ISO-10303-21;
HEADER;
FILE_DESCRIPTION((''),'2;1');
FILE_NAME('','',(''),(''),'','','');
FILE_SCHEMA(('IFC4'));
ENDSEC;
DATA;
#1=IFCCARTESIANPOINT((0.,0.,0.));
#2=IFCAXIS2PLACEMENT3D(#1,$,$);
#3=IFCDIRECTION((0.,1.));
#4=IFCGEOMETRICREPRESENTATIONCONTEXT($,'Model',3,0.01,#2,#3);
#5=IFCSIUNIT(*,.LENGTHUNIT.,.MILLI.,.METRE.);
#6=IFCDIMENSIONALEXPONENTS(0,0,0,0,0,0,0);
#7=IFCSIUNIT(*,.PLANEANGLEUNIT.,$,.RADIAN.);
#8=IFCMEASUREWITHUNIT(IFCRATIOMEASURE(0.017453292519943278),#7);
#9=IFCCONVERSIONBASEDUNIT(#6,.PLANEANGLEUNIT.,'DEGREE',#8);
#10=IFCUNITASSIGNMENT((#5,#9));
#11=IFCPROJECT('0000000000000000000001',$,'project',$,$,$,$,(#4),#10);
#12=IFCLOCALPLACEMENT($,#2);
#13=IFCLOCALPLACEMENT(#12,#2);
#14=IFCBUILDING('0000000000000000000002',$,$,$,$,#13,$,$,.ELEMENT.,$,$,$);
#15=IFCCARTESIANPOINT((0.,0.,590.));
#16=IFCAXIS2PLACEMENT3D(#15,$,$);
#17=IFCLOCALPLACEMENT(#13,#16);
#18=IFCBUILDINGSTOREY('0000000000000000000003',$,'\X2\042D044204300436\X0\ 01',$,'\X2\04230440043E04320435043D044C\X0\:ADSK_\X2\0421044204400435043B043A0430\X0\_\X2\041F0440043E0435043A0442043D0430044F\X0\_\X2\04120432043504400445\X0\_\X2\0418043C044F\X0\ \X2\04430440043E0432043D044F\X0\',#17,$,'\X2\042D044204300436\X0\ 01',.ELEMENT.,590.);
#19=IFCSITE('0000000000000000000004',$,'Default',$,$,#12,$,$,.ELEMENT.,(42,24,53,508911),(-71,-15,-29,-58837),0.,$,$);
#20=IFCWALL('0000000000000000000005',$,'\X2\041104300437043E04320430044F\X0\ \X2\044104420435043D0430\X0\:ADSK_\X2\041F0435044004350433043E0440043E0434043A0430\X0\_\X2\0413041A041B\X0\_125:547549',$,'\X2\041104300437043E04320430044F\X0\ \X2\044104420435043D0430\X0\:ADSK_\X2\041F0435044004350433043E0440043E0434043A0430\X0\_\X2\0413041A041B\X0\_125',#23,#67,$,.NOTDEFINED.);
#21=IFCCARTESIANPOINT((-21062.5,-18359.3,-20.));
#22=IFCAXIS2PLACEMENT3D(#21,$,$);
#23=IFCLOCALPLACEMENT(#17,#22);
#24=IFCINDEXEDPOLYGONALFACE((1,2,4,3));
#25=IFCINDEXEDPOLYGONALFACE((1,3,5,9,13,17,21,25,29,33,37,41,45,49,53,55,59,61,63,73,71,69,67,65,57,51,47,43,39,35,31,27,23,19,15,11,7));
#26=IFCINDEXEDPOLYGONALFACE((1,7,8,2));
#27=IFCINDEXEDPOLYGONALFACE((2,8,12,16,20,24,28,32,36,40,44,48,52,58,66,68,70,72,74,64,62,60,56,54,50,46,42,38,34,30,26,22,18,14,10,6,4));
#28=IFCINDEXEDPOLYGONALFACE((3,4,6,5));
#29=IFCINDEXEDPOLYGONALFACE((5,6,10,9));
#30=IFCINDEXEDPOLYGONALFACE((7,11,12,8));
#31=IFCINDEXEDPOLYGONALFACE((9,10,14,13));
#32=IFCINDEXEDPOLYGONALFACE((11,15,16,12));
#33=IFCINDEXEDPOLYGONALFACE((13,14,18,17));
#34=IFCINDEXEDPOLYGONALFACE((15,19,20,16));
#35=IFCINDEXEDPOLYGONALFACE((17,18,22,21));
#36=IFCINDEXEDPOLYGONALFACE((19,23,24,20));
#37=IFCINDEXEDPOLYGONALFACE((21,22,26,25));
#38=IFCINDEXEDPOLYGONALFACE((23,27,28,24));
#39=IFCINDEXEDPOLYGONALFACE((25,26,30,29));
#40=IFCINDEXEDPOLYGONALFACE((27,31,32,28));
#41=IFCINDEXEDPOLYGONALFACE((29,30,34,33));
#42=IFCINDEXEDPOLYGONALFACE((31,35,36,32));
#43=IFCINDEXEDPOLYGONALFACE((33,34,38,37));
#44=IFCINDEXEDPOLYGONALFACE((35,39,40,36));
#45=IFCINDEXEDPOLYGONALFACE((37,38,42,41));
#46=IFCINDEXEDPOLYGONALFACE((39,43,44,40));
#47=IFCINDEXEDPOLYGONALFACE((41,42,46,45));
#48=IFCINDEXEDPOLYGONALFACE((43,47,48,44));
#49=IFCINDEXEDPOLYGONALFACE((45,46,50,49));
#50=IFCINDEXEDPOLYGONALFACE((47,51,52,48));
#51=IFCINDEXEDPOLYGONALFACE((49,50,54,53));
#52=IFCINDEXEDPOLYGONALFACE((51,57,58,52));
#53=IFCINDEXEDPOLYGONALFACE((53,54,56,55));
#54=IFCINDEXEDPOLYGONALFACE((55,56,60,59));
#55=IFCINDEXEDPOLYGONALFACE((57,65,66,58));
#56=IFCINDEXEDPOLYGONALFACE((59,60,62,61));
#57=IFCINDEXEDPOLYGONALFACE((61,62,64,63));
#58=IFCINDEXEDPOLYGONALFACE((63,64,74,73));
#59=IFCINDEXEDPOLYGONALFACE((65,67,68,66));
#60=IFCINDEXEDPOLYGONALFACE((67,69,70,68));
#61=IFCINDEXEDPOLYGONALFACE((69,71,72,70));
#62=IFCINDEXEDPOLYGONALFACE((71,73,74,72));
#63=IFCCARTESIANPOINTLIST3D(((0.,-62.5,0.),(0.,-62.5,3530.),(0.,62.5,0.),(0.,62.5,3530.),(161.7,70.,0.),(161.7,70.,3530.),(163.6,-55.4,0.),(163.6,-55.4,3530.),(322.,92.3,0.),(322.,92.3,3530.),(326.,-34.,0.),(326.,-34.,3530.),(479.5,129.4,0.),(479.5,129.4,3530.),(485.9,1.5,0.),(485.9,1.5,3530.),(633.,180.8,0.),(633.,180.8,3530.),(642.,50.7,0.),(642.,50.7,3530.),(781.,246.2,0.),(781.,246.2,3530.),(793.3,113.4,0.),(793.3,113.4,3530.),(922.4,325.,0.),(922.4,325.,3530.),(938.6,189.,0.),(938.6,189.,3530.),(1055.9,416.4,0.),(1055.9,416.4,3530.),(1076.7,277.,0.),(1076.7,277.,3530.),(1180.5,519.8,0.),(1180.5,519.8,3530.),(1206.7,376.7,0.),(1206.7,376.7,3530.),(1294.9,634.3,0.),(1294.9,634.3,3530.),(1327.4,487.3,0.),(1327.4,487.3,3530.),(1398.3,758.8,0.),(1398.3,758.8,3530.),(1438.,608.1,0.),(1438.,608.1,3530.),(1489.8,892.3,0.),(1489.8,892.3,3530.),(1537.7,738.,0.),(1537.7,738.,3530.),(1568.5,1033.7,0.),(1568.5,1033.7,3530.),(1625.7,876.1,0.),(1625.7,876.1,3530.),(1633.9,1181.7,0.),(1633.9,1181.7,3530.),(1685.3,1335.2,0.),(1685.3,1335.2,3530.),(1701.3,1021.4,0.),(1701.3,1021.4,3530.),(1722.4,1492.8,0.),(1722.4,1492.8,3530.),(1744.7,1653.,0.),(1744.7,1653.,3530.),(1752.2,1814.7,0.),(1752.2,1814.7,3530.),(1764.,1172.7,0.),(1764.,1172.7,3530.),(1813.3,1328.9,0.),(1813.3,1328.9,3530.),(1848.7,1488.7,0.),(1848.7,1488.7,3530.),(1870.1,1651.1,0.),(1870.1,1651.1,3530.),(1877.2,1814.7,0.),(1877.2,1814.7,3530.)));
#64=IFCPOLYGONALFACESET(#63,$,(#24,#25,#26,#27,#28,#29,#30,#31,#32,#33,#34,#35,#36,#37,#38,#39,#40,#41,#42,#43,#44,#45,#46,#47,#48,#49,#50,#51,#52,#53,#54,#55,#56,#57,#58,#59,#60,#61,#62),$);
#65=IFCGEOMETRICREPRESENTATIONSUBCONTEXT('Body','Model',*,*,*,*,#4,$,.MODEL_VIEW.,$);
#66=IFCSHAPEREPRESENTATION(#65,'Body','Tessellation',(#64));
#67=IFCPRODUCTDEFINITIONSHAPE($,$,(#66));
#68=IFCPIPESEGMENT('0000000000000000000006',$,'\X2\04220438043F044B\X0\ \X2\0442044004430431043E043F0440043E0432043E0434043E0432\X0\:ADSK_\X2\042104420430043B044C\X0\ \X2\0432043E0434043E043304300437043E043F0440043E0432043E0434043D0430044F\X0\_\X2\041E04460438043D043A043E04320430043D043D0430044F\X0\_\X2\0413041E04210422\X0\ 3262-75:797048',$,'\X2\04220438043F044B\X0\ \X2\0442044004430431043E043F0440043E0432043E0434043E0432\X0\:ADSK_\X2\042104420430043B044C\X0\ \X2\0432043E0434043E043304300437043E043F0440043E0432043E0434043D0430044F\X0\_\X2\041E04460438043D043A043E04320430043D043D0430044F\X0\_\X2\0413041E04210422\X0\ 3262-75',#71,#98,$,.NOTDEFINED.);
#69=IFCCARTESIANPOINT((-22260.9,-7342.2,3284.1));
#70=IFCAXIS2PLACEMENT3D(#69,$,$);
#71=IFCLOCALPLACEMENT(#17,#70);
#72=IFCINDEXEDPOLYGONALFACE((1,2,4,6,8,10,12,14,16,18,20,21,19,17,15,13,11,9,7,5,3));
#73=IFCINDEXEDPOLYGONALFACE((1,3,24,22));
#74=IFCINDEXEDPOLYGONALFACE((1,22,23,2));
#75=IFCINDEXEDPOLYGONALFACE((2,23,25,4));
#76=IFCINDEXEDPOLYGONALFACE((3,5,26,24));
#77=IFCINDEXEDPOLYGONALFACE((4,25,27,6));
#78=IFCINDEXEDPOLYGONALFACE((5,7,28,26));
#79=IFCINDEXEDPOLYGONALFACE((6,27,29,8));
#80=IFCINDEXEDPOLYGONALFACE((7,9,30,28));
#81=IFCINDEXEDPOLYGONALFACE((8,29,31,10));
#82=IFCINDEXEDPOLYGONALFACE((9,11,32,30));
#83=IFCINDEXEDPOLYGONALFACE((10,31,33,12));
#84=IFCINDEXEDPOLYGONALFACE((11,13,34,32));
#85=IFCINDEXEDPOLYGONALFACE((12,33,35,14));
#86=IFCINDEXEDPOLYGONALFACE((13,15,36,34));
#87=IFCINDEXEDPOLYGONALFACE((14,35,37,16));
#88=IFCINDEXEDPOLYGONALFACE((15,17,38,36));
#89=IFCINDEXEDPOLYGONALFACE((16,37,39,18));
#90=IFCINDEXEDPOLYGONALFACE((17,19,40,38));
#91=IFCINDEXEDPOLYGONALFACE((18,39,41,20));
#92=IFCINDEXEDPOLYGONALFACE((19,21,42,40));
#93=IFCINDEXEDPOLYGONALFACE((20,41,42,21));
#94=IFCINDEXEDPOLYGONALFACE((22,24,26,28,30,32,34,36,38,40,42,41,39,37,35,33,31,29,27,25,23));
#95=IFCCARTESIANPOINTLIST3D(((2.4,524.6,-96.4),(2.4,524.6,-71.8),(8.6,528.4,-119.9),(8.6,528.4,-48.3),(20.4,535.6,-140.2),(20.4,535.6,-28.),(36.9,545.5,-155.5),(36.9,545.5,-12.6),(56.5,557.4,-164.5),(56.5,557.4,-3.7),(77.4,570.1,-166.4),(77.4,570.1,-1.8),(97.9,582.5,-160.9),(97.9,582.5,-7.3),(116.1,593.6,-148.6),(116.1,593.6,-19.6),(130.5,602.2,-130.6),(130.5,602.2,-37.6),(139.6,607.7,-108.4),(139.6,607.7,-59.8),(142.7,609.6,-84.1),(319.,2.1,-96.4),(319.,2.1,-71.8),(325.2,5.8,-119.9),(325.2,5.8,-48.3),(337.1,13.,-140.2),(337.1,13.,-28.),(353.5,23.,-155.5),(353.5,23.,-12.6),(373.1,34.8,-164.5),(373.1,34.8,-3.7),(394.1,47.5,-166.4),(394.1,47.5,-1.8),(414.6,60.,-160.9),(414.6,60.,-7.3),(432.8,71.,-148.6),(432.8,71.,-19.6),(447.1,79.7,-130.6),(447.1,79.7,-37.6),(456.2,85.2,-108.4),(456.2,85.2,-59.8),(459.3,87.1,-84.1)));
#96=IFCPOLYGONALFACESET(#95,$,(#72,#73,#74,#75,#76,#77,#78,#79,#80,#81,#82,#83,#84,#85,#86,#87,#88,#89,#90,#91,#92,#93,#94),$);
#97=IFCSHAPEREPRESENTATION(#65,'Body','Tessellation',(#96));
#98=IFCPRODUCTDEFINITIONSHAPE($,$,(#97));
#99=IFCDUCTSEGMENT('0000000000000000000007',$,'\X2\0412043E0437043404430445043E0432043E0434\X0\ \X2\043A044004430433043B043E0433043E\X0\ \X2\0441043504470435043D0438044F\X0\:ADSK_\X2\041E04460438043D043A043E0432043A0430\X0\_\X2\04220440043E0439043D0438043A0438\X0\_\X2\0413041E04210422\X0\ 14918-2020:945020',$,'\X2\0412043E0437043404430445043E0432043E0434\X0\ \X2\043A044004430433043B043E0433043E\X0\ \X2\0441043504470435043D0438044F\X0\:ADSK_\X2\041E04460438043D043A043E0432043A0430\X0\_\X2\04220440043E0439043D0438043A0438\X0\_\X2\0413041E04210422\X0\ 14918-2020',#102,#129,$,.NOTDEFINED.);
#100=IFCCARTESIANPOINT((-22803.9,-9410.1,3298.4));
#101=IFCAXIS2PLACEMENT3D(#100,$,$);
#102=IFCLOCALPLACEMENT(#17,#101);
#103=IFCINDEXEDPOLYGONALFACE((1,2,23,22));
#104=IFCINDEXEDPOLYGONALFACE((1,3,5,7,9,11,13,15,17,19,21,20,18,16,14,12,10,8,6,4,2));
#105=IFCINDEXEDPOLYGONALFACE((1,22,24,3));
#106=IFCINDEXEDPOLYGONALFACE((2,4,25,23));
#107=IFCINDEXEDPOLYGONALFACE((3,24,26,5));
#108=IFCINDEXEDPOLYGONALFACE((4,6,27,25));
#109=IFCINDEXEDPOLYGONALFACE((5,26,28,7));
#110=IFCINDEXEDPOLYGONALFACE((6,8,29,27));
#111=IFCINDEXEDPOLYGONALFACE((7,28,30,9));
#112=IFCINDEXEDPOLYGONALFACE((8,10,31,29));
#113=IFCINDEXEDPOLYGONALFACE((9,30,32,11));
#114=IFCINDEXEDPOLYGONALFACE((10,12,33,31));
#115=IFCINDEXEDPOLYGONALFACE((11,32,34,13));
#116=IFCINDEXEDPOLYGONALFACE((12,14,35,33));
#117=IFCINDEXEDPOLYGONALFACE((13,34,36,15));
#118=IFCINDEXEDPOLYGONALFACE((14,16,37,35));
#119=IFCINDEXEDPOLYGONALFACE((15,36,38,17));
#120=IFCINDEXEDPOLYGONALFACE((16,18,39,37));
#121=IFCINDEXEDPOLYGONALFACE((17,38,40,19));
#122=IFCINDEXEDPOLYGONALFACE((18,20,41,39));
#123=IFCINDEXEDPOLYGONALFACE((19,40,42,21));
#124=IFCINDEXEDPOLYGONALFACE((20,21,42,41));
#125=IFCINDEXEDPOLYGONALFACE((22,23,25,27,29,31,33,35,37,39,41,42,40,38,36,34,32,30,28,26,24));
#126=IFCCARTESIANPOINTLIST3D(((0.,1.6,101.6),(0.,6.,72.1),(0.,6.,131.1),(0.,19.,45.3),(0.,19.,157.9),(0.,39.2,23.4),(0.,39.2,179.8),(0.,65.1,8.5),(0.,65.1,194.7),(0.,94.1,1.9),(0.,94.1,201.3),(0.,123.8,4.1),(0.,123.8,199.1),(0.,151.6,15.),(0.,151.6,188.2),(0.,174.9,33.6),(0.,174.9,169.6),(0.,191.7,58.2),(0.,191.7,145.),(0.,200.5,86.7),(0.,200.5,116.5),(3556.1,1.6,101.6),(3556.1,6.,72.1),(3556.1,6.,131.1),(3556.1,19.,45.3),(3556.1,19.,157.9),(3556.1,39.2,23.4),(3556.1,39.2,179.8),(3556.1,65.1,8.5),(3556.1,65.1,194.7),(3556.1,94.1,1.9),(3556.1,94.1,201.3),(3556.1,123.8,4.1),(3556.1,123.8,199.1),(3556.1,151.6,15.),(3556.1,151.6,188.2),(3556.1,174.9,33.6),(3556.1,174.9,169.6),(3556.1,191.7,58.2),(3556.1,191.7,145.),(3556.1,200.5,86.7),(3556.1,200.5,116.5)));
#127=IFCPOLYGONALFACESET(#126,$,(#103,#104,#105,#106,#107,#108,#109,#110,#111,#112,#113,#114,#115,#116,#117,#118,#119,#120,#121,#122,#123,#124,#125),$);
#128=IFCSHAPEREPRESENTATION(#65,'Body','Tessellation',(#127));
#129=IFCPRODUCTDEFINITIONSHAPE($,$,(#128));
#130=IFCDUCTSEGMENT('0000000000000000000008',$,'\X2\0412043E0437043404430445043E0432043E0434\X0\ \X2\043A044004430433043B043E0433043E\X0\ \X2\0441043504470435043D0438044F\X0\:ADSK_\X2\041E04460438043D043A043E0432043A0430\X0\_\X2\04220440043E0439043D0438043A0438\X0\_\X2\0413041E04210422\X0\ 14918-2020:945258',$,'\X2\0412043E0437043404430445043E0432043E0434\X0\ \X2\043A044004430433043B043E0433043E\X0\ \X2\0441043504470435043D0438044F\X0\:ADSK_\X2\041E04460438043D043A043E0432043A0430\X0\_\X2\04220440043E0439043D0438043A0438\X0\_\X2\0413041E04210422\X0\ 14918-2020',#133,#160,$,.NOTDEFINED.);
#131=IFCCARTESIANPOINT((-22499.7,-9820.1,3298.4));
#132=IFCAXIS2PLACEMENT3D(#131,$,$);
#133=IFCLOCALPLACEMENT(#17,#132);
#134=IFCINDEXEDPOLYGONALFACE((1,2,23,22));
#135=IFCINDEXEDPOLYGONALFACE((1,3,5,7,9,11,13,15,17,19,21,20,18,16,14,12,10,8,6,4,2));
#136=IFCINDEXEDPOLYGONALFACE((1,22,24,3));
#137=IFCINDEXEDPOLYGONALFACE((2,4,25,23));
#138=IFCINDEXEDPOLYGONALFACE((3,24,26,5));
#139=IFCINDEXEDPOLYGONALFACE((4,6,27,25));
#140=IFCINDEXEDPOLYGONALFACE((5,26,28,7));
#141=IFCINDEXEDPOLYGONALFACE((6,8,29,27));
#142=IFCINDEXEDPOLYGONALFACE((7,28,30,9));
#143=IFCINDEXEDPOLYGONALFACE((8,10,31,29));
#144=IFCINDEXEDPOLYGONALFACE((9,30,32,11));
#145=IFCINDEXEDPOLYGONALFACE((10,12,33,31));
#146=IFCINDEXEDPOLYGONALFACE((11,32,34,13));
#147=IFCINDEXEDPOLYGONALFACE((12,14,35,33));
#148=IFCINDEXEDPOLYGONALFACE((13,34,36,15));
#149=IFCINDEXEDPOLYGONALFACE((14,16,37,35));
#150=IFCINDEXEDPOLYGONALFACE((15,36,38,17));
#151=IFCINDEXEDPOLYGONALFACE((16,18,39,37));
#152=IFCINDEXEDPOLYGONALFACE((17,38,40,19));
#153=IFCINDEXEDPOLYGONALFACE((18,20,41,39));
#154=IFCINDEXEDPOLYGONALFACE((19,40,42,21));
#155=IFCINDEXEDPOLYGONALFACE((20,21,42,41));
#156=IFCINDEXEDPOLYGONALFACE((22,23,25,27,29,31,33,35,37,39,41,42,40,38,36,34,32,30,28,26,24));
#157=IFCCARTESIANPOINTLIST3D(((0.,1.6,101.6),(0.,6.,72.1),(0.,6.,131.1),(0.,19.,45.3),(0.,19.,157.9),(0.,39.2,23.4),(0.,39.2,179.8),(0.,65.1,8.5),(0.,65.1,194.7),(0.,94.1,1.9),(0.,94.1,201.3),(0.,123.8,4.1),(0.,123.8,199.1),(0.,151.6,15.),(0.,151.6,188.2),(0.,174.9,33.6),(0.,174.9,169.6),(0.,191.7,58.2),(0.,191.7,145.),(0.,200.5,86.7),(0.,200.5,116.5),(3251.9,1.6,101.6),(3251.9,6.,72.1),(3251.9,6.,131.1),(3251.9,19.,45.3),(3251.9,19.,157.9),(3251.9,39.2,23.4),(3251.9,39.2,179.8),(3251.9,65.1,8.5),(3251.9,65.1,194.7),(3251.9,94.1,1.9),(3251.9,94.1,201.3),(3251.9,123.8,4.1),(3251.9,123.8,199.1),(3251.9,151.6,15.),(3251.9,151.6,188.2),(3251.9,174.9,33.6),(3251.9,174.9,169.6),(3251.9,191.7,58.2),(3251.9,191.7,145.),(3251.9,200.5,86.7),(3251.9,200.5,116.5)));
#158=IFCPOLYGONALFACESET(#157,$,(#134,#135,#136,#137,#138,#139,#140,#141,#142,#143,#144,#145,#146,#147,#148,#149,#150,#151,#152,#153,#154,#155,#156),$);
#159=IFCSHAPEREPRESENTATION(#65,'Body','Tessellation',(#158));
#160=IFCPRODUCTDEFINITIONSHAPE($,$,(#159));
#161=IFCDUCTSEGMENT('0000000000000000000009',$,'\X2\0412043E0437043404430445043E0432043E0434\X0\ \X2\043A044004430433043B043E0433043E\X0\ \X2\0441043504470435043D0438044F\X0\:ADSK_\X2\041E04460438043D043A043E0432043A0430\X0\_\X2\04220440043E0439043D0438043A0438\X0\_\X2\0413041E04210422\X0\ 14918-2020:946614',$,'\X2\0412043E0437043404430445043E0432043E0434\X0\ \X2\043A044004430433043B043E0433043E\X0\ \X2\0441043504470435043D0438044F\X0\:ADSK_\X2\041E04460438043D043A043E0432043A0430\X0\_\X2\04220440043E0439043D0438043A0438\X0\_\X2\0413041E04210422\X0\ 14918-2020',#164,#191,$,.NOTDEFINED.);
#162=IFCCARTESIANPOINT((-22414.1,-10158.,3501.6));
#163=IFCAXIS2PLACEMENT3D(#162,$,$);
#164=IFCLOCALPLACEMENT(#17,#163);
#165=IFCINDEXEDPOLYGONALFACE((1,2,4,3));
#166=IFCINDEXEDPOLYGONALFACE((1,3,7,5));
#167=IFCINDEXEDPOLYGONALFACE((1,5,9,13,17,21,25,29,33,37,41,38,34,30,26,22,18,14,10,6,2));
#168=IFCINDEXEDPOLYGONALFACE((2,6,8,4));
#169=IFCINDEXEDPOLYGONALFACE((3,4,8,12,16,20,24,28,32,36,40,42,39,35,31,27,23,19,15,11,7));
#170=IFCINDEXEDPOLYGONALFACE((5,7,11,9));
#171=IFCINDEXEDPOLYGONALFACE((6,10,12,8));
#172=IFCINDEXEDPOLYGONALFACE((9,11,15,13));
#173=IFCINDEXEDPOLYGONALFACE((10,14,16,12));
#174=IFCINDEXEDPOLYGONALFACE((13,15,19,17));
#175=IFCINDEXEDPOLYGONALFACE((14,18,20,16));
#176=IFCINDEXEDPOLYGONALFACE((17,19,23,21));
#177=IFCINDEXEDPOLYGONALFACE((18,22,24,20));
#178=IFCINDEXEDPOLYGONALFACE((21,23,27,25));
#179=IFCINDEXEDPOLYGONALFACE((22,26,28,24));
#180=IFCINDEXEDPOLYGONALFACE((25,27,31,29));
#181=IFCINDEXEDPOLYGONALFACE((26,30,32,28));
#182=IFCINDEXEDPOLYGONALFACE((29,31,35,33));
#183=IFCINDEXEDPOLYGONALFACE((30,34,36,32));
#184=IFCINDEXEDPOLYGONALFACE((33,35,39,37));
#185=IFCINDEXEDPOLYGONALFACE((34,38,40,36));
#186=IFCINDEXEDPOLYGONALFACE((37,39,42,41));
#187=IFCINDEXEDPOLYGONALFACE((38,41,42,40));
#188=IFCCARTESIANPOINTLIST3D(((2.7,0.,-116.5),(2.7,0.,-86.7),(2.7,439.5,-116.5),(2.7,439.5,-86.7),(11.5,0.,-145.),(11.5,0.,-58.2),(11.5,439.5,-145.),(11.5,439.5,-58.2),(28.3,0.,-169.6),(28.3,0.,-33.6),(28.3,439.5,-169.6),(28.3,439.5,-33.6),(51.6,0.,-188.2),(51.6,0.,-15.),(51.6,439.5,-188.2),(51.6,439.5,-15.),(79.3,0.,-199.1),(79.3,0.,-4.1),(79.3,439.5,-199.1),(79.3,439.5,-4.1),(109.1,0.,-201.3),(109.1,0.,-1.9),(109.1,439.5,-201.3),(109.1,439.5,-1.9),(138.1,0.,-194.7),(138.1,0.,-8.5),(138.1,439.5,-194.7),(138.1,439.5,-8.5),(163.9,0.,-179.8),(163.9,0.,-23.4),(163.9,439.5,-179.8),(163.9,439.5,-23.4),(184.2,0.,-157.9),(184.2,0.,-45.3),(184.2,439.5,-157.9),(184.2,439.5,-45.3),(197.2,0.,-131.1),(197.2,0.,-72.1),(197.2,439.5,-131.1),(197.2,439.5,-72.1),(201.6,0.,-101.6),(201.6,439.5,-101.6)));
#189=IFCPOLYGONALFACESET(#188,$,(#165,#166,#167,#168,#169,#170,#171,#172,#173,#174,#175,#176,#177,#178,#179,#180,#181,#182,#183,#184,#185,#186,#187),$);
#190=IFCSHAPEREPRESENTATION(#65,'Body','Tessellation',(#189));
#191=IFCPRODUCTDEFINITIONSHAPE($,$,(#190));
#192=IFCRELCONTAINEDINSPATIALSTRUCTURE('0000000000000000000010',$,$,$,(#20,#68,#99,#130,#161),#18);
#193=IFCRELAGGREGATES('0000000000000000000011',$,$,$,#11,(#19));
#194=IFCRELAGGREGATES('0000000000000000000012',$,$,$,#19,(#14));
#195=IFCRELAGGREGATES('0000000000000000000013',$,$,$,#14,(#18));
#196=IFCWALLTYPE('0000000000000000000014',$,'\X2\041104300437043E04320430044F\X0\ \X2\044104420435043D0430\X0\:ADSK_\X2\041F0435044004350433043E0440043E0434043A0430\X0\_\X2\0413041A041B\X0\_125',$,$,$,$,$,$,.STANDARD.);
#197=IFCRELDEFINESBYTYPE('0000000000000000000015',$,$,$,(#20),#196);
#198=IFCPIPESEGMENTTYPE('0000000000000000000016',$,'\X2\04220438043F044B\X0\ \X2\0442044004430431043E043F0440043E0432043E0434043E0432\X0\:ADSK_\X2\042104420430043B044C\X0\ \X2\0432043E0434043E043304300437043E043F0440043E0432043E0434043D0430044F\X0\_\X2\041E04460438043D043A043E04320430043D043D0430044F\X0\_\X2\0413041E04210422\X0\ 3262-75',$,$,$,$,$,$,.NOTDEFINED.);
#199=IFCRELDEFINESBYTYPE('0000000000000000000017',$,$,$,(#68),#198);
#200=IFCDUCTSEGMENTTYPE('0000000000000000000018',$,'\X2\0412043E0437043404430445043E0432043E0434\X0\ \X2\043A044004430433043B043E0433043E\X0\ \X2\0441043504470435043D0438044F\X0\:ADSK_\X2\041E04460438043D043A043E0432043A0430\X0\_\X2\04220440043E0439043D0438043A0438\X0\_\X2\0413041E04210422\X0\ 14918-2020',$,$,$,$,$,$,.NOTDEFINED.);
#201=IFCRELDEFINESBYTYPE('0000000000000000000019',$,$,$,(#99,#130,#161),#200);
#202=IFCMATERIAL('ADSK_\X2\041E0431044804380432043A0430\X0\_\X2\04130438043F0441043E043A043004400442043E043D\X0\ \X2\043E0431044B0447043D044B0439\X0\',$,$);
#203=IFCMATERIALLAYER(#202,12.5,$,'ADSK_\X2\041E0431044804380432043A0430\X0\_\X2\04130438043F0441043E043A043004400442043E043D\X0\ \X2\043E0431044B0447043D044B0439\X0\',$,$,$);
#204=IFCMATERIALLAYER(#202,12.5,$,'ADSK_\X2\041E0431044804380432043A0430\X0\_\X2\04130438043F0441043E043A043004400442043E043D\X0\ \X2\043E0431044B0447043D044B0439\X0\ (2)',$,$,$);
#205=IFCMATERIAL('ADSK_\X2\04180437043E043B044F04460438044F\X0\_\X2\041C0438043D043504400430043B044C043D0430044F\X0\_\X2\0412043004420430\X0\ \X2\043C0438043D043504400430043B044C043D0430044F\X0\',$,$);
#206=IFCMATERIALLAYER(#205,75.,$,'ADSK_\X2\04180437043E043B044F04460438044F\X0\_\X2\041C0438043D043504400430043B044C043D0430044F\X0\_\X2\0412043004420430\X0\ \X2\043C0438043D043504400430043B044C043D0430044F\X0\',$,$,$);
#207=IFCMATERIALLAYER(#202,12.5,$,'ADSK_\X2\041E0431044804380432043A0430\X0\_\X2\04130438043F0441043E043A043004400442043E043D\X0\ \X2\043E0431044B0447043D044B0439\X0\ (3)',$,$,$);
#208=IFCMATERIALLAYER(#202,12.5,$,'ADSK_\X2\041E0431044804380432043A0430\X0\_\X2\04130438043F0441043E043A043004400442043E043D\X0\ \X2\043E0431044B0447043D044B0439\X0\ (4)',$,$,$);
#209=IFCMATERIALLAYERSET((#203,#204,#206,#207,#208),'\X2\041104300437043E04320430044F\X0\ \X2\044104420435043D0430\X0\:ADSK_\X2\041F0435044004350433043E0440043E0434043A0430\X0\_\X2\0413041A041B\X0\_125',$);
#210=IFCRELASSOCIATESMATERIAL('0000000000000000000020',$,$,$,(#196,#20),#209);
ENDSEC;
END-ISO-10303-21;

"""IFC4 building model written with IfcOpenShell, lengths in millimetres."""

from ifc_helpers import new_model, entity, si_unit, converted_unit, direction, frame, frame_2d, origin, origin_2d_with_axis, place, context, subcontext, project, spatial, polyline, circle_curve, parameter, trimmed, segment, composite_curve, circle, outline, extrude, material, layer, layer_set, layer_usage, type_object, element, save


model = new_model("IFC4")

# Units and contexts
model_context = context("Model", 3, precision=0.01, world=origin(), true_north=direction((0.0, 1.0)))
body_context = subcontext(model_context, "Body", "Model", "MODEL_VIEW")
ifc_project = project(units=[si_unit("LENGTHUNIT", "METRE", prefix="MILLI"), converted_unit("PLANEANGLEUNIT", "DEGREE", entity("IfcRatioMeasure", 0.017453292519943278), si_unit("PLANEANGLEUNIT", "RADIAN"), dimensions=[0, 0, 0, 0, 0, 0, 0])], contexts=[model_context])

# Site, building, storey
site_placement = place(None, origin())
site = spatial("IfcSite", under=ifc_project, at=site_placement, Name="Default", CompositionType="ELEMENT", RefLatitude=(42, 24, 53, 508911), RefLongitude=(-71, -15, -29, -58837), RefElevation=0.0)
building_placement = place(site_placement, origin())
building = spatial("IfcBuilding", under=site, at=building_placement, CompositionType="ELEMENT")
storey_placement = place(building_placement, frame((0.0, 0.0, 590.0)))
storey = spatial("IfcBuildingStorey", under=building, at=storey_placement, Name="Этаж 01", ObjectType="Уровень:ADSK_Стрелка_Проектная_Вверх_Имя уровня", LongName="Этаж 01", CompositionType="ELEMENT", Elevation=590.0)

# Shared definitions
ifc_material_1 = material(Name="ADSK_Обшивка_Гипсокартон обычный")
ifc_layer_1 = layer(ifc_material_1, 12.5, Name="ADSK_Обшивка_Гипсокартон обычный")
ifc_layer_2 = layer(ifc_material_1, 12.5, Name="ADSK_Обшивка_Гипсокартон обычный (2)")
ifc_material_2 = material(Name="ADSK_Изоляция_Минеральная_Вата минеральная")
ifc_layer_3 = layer(ifc_material_2, 75.0, Name="ADSK_Изоляция_Минеральная_Вата минеральная")
ifc_layer_4 = layer(ifc_material_1, 12.5, Name="ADSK_Обшивка_Гипсокартон обычный (3)")
ifc_layer_5 = layer(ifc_material_1, 12.5, Name="ADSK_Обшивка_Гипсокартон обычный (4)")
ifc_layer_set_1 = layer_set([ifc_layer_1, ifc_layer_2, ifc_layer_3, ifc_layer_4, ifc_layer_5], Name="Базовая стена:ADSK_Перегородка_ГКЛ_125")
wall_type_1 = type_object("IfcWallType", Name="Базовая стена:ADSK_Перегородка_ГКЛ_125", PredefinedType="STANDARD", material=ifc_layer_set_1)

# Wall
ifc_layer_usage_1 = layer_usage(ifc_layer_set_1, "AXIS2", "NEGATIVE", 62.5)
wall_1_placement = place(storey_placement, frame((-21062.5, -18359.3, -20.0)))
element("IfcWall", 1, at=wall_1_placement, inside=storey, type_object=wall_type_1, material=ifc_layer_usage_1, Name="Базовая стена:ADSK_Перегородка_ГКЛ_125:547549", ObjectType="Базовая стена:ADSK_Перегородка_ГКЛ_125", PredefinedType="NOTDEFINED", context=body_context, shape_type="SweptSolid", body=[
    extrude(outline(composite_curve([segment(trimmed(circle_curve(frame_2d((0.0, 1814.7), x_axis=(1.0, 0.0)), 1752.2), [parameter(270.0)], [parameter(0.0)], True, "PARAMETER"), False, "CONTINUOUS"), segment(polyline([(0.0, 62.5), (0.0, -62.5)]), True, "CONTINUOUS"), segment(trimmed(circle_curve(frame_2d((0.0, 1814.7), x_axis=(1.0, 0.0)), 1877.2), [parameter(270.0)], [parameter(0.0)], True, "PARAMETER"), True, "CONTINUOUS"), segment(polyline([(1877.2, 1814.7), (1752.2, 1814.7)]), True, "CONTINUOUS")], self_intersect=False)), origin(), (0.0, 0.0, 1.0), 3530.0),
])

# Pipe segment
pipe_segment_type = type_object("IfcPipeSegmentType", Name="Типы трубопроводов:ADSK_Сталь водогазопроводная_Оцинкованная_ГОСТ 3262-75", PredefinedType="NOTDEFINED")
pipe_segment_1_placement = place(storey_placement, frame((-22260.9, -7342.2, 3284.1)))
element("IfcPipeSegment", 2, at=pipe_segment_1_placement, inside=storey, type_object=pipe_segment_type, Name="Типы трубопроводов:ADSK_Сталь водогазопроводная_Оцинкованная_ГОСТ 3262-75:797048", ObjectType="Типы трубопроводов:ADSK_Сталь водогазопроводная_Оцинкованная_ГОСТ 3262-75", PredefinedType="NOTDEFINED", context=body_context, shape_type="SweptSolid", body=[
    extrude(circle(Radius=82.5, at=frame_2d((0.0, 0.0), x_axis=(1.0, 0.0))), frame((72.2, 566.9, -84.1), z_axis=(0.518223, -0.855246, 0.0), x_axis=(0.855246, 0.518223, 0.0)), (0.0, 0.0, 1.0), 611.0),
])

# Duct segments
duct_segment_type = type_object("IfcDuctSegmentType", Name="Воздуховод круглого сечения:ADSK_Оцинковка_Тройники_ГОСТ 14918-2020", PredefinedType="NOTDEFINED")
duct_segment_1_placement = place(storey_placement, frame((-22803.9, -9410.1, 3298.4)))
element("IfcDuctSegment", 3, at=duct_segment_1_placement, inside=storey, type_object=duct_segment_type, Name="Воздуховод круглого сечения:ADSK_Оцинковка_Тройники_ГОСТ 14918-2020:945020", ObjectType="Воздуховод круглого сечения:ADSK_Оцинковка_Тройники_ГОСТ 14918-2020", PredefinedType="NOTDEFINED", context=body_context, shape_type="SweptSolid", body=[
    extrude(circle(Radius=100.0, at=origin_2d_with_axis()), frame((0.0, 101.6, 101.6), z_axis=(1.0, 0.0, 0.0), x_axis=(0.0, -1.0, 0.0)), (0.0, 0.0, 1.0), 3556.1),
])
duct_segment_2_placement = place(storey_placement, frame((-22499.7, -9820.1, 3298.4)))
element("IfcDuctSegment", 4, at=duct_segment_2_placement, inside=storey, type_object=duct_segment_type, Name="Воздуховод круглого сечения:ADSK_Оцинковка_Тройники_ГОСТ 14918-2020:945258", ObjectType="Воздуховод круглого сечения:ADSK_Оцинковка_Тройники_ГОСТ 14918-2020", PredefinedType="NOTDEFINED", context=body_context, shape_type="SweptSolid", body=[
    extrude(circle(Radius=100.0, at=origin_2d_with_axis()), frame((0.0, 101.6, 101.6), z_axis=(1.0, 0.0, 0.0), x_axis=(0.0, -1.0, 0.0)), (0.0, 0.0, 1.0), 3251.9),
])
duct_segment_3_placement = place(storey_placement, frame((-22414.1, -10158.0, 3501.6)))
element("IfcDuctSegment", 5, at=duct_segment_3_placement, inside=storey, type_object=duct_segment_type, Name="Воздуховод круглого сечения:ADSK_Оцинковка_Тройники_ГОСТ 14918-2020:946614", ObjectType="Воздуховод круглого сечения:ADSK_Оцинковка_Тройники_ГОСТ 14918-2020", PredefinedType="NOTDEFINED", context=body_context, shape_type="SweptSolid", body=[
    extrude(circle(Radius=100.0, at=origin_2d_with_axis()), frame((101.6, 0.0, -101.6), z_axis=(0.0, 1.0, 0.0), x_axis=(1.0, 0.0, 0.0)), (0.0, 0.0, 1.0), 439.5),
])

save(model, "model.ifc")
